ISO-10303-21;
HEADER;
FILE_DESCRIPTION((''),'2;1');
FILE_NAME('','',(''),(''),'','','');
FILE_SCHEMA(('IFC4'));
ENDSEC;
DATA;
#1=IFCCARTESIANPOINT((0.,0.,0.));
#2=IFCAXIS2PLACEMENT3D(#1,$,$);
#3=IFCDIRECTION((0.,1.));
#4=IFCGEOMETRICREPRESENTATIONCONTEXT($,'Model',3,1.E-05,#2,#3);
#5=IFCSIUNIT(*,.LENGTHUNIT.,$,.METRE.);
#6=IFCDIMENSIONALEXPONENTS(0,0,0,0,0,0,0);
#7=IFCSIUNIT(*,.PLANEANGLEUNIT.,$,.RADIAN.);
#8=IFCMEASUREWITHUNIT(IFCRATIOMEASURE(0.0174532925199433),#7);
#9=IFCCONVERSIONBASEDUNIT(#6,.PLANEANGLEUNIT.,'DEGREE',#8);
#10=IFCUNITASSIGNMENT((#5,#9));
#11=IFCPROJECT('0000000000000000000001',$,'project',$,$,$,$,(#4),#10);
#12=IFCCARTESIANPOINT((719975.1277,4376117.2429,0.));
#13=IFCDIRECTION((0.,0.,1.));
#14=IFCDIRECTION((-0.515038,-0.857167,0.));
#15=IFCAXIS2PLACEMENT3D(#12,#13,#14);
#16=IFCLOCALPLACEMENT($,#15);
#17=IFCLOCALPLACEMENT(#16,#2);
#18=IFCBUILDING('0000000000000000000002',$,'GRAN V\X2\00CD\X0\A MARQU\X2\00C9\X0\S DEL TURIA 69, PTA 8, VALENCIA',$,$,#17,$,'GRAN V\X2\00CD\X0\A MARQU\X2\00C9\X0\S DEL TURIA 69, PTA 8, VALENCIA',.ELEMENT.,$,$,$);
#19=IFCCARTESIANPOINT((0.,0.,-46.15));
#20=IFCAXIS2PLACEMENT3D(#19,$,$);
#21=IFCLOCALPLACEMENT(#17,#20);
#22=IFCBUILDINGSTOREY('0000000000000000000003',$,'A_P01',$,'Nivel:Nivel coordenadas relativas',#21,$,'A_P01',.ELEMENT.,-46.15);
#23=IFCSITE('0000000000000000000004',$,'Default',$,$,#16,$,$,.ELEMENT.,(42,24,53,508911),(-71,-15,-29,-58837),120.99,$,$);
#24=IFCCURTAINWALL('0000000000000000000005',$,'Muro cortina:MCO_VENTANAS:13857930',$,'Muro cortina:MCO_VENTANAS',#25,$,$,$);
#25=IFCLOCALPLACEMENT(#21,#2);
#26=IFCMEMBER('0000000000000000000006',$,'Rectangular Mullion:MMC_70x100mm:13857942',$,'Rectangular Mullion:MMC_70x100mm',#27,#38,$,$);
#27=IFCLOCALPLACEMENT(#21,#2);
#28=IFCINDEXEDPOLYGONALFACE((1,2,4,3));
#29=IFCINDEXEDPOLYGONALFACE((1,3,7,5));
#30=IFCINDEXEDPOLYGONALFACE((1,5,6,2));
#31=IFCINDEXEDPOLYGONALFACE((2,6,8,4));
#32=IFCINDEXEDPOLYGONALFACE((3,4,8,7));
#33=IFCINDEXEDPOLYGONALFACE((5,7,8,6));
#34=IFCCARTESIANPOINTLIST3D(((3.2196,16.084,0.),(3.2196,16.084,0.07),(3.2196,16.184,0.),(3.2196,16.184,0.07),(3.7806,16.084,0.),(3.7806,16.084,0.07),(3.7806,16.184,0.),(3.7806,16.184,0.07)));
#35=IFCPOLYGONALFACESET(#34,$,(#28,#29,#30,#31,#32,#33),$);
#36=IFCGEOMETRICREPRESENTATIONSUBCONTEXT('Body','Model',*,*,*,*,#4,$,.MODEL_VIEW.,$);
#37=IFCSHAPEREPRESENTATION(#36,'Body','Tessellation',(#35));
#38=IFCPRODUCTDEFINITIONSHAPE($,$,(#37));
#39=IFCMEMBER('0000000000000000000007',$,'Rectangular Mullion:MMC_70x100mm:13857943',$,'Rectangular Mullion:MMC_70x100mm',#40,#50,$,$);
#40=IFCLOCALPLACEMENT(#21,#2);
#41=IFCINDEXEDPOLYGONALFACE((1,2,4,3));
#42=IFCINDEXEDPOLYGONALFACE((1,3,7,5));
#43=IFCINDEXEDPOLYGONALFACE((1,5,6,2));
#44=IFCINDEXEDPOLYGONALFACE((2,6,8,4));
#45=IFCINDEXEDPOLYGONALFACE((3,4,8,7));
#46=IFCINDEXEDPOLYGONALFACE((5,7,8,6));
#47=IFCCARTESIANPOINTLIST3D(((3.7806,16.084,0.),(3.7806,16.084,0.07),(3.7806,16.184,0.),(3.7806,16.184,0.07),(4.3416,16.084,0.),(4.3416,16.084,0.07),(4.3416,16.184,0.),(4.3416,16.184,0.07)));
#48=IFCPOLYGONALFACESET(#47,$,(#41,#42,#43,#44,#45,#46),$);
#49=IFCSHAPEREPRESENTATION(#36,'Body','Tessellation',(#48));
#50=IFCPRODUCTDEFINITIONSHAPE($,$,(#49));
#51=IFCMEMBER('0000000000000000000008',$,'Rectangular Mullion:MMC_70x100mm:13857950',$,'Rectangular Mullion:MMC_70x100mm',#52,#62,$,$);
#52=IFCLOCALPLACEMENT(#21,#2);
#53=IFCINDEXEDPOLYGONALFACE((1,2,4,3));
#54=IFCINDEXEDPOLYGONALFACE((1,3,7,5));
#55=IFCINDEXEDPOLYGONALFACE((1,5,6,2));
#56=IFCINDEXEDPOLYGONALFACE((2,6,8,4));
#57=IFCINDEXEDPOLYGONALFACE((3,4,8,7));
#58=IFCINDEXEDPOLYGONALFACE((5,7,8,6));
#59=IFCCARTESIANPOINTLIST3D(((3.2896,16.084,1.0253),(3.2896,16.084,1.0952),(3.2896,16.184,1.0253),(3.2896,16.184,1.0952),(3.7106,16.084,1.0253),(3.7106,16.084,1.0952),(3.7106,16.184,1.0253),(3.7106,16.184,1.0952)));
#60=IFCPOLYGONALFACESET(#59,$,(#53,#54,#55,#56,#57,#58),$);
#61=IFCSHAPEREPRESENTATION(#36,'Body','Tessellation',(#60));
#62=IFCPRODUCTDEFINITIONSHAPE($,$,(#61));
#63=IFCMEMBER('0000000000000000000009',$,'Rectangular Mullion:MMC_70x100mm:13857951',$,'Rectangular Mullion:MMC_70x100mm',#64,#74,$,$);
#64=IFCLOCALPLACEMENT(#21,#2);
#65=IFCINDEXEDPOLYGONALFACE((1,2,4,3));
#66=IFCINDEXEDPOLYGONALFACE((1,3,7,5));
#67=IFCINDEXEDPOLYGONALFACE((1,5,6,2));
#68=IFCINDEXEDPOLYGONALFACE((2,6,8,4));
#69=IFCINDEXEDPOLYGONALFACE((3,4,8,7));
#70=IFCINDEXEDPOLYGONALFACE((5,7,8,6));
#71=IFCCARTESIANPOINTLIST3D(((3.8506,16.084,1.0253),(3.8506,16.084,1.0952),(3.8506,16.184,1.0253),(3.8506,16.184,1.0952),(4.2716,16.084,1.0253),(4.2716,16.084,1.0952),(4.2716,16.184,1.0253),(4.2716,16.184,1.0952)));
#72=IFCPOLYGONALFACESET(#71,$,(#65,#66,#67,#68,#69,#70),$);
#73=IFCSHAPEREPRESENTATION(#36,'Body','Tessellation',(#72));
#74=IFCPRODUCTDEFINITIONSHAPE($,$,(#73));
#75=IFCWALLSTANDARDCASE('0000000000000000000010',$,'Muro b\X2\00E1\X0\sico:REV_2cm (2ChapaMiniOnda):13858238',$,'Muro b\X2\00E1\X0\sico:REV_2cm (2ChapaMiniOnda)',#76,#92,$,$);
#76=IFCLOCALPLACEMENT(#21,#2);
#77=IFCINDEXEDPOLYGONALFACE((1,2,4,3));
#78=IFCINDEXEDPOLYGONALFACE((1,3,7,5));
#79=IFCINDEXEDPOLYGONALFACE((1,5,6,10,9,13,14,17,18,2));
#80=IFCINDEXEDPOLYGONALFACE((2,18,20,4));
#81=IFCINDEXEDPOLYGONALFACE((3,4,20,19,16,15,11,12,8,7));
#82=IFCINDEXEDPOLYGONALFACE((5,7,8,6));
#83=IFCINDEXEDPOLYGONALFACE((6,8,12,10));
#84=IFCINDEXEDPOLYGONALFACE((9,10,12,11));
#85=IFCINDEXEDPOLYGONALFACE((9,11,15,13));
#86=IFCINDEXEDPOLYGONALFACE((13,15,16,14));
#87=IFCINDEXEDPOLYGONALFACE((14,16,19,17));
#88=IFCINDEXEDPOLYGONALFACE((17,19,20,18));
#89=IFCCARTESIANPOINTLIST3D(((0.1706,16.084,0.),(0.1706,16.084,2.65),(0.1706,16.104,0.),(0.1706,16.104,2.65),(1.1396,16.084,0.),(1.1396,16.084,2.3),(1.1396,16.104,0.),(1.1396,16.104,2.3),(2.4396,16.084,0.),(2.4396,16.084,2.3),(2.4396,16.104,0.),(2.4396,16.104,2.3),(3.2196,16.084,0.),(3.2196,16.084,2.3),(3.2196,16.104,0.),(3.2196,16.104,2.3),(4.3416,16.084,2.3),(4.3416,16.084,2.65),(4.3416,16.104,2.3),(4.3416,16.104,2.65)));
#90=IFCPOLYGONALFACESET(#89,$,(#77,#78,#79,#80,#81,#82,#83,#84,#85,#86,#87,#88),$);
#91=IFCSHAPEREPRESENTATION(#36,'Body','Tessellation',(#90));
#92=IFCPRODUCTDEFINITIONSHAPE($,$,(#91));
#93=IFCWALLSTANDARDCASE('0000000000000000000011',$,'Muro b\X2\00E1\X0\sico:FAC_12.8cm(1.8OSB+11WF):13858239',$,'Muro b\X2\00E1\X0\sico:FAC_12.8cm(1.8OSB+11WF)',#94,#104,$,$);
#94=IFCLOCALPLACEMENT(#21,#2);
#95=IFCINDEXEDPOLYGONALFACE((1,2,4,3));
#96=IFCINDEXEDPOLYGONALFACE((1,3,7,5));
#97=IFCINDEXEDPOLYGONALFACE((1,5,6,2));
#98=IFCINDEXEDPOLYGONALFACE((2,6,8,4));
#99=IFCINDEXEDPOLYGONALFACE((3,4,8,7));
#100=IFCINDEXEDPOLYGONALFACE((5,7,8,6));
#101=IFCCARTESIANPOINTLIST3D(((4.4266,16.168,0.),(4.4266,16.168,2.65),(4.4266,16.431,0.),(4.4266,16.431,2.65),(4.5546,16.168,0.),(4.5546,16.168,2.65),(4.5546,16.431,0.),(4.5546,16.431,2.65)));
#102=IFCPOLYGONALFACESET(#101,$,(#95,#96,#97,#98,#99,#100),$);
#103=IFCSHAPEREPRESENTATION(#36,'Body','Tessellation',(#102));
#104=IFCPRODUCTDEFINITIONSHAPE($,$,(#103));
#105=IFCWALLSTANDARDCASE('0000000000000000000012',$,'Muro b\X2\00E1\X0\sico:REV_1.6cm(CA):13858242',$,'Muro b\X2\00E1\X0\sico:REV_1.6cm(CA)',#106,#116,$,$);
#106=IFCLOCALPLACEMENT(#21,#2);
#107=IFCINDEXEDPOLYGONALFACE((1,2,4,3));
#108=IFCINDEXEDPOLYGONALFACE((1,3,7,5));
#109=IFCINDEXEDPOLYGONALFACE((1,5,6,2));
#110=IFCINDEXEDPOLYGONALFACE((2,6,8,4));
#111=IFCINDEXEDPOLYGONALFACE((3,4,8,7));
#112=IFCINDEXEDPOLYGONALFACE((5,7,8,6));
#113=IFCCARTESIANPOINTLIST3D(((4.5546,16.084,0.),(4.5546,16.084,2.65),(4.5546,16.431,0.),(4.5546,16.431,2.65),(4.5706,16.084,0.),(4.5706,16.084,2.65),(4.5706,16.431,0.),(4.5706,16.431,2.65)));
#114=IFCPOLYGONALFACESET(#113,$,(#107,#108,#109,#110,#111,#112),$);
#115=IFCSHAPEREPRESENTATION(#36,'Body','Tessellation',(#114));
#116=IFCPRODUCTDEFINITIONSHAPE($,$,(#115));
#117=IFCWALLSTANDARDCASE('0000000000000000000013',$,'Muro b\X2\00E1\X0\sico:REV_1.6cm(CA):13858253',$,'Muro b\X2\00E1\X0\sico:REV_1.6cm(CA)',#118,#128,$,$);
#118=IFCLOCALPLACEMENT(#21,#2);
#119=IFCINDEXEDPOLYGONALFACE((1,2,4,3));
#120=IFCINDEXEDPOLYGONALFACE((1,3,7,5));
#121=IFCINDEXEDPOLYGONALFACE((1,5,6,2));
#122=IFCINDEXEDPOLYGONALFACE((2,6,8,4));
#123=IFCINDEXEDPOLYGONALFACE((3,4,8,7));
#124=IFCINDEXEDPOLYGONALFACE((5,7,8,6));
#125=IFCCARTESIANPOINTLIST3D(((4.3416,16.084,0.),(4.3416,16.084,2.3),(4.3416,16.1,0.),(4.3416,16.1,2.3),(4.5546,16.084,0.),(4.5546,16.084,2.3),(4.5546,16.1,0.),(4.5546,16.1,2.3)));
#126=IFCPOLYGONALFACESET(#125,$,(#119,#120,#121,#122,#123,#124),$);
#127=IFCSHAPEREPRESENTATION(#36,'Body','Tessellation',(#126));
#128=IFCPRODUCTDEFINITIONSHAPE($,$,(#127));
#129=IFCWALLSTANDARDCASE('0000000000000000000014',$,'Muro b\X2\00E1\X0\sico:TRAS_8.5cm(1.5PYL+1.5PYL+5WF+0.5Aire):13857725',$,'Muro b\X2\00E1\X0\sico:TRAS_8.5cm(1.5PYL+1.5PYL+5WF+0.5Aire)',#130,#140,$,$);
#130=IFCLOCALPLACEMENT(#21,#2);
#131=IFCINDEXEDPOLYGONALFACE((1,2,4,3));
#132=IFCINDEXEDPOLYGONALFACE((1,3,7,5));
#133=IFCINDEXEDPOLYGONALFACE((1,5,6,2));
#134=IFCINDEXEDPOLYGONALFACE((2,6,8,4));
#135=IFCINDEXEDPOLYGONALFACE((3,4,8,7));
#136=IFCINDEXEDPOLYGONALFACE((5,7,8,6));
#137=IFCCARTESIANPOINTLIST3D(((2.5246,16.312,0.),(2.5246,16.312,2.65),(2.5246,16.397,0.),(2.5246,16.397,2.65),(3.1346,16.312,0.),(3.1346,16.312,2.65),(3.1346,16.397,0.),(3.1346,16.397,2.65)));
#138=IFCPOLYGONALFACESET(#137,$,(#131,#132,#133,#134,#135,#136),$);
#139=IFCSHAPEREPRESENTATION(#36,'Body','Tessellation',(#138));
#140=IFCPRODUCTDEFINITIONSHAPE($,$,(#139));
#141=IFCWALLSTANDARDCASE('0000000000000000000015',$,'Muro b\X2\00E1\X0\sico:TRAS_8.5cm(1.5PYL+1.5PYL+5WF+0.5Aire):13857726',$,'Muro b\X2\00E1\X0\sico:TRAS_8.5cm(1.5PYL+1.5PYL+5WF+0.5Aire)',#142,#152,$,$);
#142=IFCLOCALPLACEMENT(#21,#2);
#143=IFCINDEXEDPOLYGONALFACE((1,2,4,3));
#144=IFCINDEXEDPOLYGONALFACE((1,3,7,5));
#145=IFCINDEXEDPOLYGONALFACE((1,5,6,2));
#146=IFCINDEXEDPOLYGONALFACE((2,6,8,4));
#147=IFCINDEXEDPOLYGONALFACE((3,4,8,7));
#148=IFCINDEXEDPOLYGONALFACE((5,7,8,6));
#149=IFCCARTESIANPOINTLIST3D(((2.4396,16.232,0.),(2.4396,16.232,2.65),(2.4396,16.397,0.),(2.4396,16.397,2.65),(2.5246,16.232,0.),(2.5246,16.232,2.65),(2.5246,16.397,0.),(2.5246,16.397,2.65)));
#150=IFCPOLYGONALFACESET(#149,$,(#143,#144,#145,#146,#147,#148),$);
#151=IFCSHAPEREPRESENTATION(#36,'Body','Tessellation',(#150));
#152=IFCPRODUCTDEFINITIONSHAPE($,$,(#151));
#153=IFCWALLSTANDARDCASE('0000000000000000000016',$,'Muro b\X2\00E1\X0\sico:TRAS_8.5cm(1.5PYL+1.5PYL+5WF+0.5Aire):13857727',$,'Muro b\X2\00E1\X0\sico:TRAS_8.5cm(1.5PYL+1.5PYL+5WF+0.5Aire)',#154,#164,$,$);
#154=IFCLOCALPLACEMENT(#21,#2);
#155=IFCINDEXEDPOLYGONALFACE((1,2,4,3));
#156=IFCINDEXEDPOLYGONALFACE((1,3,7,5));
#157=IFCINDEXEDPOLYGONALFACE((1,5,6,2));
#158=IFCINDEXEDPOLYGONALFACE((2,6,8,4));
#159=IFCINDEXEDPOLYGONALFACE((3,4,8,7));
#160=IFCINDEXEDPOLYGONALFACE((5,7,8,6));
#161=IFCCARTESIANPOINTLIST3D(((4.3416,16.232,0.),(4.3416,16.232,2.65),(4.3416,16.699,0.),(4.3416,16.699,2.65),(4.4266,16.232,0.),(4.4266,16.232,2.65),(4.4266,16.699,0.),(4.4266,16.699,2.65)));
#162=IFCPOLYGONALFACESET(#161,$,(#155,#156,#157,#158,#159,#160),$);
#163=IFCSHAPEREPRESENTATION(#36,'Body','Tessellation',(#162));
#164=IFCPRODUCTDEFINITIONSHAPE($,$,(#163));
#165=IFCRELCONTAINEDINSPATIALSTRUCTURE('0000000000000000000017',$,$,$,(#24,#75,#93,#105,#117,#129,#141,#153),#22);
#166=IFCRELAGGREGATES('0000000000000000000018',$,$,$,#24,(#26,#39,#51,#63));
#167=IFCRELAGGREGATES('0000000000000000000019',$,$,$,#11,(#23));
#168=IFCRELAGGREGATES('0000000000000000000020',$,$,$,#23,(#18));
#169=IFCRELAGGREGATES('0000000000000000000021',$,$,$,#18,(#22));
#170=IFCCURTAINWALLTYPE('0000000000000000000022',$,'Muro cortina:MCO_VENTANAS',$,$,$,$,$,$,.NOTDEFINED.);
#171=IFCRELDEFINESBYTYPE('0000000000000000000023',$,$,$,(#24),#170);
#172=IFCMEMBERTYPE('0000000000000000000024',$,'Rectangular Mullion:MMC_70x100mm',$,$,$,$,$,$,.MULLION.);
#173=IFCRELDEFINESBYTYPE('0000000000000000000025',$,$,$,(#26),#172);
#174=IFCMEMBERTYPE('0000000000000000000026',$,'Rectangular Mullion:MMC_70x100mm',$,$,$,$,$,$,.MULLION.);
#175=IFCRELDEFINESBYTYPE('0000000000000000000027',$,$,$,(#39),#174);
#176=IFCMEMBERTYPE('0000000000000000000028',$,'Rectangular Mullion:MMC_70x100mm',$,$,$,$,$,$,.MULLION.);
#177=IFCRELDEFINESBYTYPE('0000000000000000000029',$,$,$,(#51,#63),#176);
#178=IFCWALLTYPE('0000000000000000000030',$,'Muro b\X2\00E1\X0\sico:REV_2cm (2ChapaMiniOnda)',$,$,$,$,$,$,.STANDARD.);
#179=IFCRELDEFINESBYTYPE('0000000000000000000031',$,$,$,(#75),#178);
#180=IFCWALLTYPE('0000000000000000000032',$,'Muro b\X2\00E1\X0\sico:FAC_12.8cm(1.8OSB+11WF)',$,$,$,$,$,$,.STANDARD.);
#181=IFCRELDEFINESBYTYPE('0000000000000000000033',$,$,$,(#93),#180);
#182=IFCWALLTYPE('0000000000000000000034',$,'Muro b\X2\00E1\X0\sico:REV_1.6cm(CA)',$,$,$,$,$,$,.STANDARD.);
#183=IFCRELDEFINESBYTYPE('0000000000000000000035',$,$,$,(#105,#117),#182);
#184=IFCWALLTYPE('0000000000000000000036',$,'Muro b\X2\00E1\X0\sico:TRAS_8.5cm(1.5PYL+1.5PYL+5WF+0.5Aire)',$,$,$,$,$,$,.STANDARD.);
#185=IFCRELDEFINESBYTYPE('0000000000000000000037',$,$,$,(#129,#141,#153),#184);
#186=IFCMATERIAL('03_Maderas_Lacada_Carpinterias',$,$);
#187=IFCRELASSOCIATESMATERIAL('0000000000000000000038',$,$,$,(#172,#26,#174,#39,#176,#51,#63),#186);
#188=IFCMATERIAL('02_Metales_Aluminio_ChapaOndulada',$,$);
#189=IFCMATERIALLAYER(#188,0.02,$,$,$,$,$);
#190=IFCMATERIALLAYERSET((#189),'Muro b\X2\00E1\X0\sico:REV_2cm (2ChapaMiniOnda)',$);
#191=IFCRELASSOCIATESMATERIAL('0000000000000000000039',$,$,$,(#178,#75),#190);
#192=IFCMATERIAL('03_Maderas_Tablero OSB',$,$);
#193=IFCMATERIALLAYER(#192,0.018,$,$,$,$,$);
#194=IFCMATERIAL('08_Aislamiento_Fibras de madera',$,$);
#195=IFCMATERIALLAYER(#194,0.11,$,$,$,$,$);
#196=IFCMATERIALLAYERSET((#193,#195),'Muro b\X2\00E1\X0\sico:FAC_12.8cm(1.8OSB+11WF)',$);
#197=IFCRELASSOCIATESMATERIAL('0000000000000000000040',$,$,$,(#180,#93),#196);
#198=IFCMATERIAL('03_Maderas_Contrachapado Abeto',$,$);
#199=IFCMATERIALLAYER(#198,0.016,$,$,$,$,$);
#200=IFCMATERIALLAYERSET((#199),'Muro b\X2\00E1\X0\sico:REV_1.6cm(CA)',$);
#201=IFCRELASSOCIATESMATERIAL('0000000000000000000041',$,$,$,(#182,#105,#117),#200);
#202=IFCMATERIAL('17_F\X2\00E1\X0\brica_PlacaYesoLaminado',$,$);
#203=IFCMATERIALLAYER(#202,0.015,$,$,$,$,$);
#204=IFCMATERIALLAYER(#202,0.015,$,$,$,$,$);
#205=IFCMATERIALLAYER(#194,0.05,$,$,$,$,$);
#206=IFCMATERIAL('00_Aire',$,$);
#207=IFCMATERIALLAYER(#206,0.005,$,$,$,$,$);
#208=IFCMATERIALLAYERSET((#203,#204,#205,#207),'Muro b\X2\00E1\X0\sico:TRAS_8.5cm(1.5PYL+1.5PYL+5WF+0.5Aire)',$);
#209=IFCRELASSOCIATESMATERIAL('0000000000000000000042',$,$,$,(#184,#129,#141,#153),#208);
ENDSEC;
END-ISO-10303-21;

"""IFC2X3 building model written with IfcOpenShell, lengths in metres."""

from ifc_helpers import new_model, entity, si_unit, converted_unit, direction, frame, frame_2d, origin, origin_2d_with_axis, place, context, subcontext, project, spatial, rectangle, extrude, source, transform, mapped, material, layer, layer_set, layer_usage, type_object, type_shapes, element, aggregate, save


model = new_model("IFC2X3")

# Units and contexts
model_context = context("Model", 3, precision=1e-05, world=origin(), true_north=direction((0.0, 1.0)))
body_context = subcontext(model_context, "Body", "Model", "MODEL_VIEW")
ifc_project = project(units=[si_unit("LENGTHUNIT", "METRE"), converted_unit("PLANEANGLEUNIT", "DEGREE", entity("IfcRatioMeasure", 0.0174532925199433), si_unit("PLANEANGLEUNIT", "RADIAN"), dimensions=[0, 0, 0, 0, 0, 0, 0])], contexts=[model_context])

# Site, building, storey
site_placement = place(None, frame((719975.1277, 4376117.2429, 0.0), z_axis=(0.0, 0.0, 1.0), x_axis=(-0.515038, -0.857167, 0.0)))
site = spatial("IfcSite", under=ifc_project, at=site_placement, Name="Default", CompositionType="ELEMENT", RefLatitude=(42, 24, 53, 508911), RefLongitude=(-71, -15, -29, -58837), RefElevation=120.99)
building_placement = place(site_placement, origin())
building = spatial("IfcBuilding", under=site, at=building_placement, Name="GRAN VÍA MARQUÉS DEL TURIA 69, PTA 8, VALENCIA", LongName="GRAN VÍA MARQUÉS DEL TURIA 69, PTA 8, VALENCIA", CompositionType="ELEMENT")
storey_placement = place(building_placement, frame((0.0, 0.0, -46.15)))
storey = spatial("IfcBuildingStorey", under=building, at=storey_placement, Name="A_P01", ObjectType="Nivel:Nivel coordenadas relativas", LongName="A_P01", CompositionType="ELEMENT", Elevation=-46.15)

# Shared definitions
curtain_wall_type = type_object("IfcCurtainWallType", Name="Muro cortina:MCO_VENTANAS", PredefinedType="NOTDEFINED")
ifc_material_1 = material(Name="03_Maderas_Lacada_Carpinterias")

# Curtain wall
curtain_wall_1_placement = place(storey_placement, frame((0.0, 0.0, 46.15)))
curtain_wall_1 = element("IfcCurtainWall", 1, at=curtain_wall_1_placement, inside=storey, type_object=curtain_wall_type, Name="Muro cortina:MCO_VENTANAS:13857930", ObjectType="Muro cortina:MCO_VENTANAS")

# Members
member_type_1 = type_object("IfcMemberType", Name="Rectangular Mullion:MMC_70x100mm", PredefinedType="MULLION", material=ifc_material_1)
shared_shape_1 = source(origin(), body_context, "Body", "SweptSolid", [
    extrude(rectangle(XDim=0.1, YDim=0.07, at=origin_2d_with_axis()), frame((-0.035, 0.0, -0.561), z_axis=(0.0, 0.0, 1.0), x_axis=(0.0, -1.0, 0.0)), (0.0, 0.0, 1.0), 0.561),
])
type_shapes(member_type_1, [shared_shape_1])
member_1_placement = place(storey_placement, frame((3.2196, 16.134, 0.0), z_axis=(-1.0, 0.0, 0.0), x_axis=(0.0, 0.0, -1.0)))
member_1 = element("IfcMember", 2, at=member_1_placement, type_object=member_type_1, material=ifc_material_1, Name="Rectangular Mullion:MMC_70x100mm:13857942", ObjectType="Rectangular Mullion:MMC_70x100mm", context=body_context, shape_type="MappedRepresentation", body=[
    mapped(shared_shape_1, transform((0.0, 0.0, 0.0), scale=1.0)),
])
member_type_2 = type_object("IfcMemberType", Name="Rectangular Mullion:MMC_70x100mm", PredefinedType="MULLION", material=ifc_material_1)
shared_shape_2 = source(origin(), body_context, "Body", "SweptSolid", [
    extrude(rectangle(XDim=0.1, YDim=0.07, at=origin_2d_with_axis()), frame((-0.035, 0.0, -0.561), z_axis=(0.0, 0.0, 1.0), x_axis=(0.0, -1.0, 0.0)), (0.0, 0.0, 1.0), 0.561),
])
type_shapes(member_type_2, [shared_shape_2])
member_2_placement = place(storey_placement, frame((3.7806, 16.134, 0.0), z_axis=(-1.0, 0.0, 0.0), x_axis=(0.0, 0.0, -1.0)))
member_2 = element("IfcMember", 3, at=member_2_placement, type_object=member_type_2, material=ifc_material_1, Name="Rectangular Mullion:MMC_70x100mm:13857943", ObjectType="Rectangular Mullion:MMC_70x100mm", context=body_context, shape_type="MappedRepresentation", body=[
    mapped(shared_shape_2, transform((0.0, 0.0, 0.0), scale=1.0)),
])
member_type_3 = type_object("IfcMemberType", Name="Rectangular Mullion:MMC_70x100mm", PredefinedType="MULLION", material=ifc_material_1)
shared_shape_3 = source(origin(), body_context, "Body", "SweptSolid", [
    extrude(rectangle(XDim=0.1, YDim=0.07, at=origin_2d_with_axis()), frame((0.0, 0.0, -0.421), z_axis=(0.0, 0.0, 1.0), x_axis=(0.0, -1.0, 0.0)), (0.0, 0.0, 1.0), 0.421),
])
type_shapes(member_type_3, [shared_shape_3])
member_3_placement = place(storey_placement, frame((3.7106, 16.134, 1.0602), z_axis=(1.0, 0.0, 0.0), x_axis=(0.0, 0.0, 1.0)))
member_3 = element("IfcMember", 4, at=member_3_placement, type_object=member_type_3, material=ifc_material_1, Name="Rectangular Mullion:MMC_70x100mm:13857950", ObjectType="Rectangular Mullion:MMC_70x100mm", context=body_context, shape_type="MappedRepresentation", body=[
    mapped(shared_shape_3, transform((0.0, 0.0, 0.0), scale=1.0)),
])
member_4_placement = place(storey_placement, frame((4.2716, 16.134, 1.0602), z_axis=(1.0, 0.0, 0.0), x_axis=(0.0, 0.0, 1.0)))
member_4 = element("IfcMember", 5, at=member_4_placement, type_object=member_type_3, material=ifc_material_1, Name="Rectangular Mullion:MMC_70x100mm:13857951", ObjectType="Rectangular Mullion:MMC_70x100mm", context=body_context, shape_type="MappedRepresentation", body=[
    mapped(shared_shape_3, transform((0.0, 0.0, 0.0), scale=1.0)),
])

aggregate(curtain_wall_1, [member_1, member_2, member_3, member_4])

# Wall, openings
ifc_material_2 = material(Name="02_Metales_Aluminio_ChapaOndulada")
ifc_layer_1 = layer(ifc_material_2, 0.02)
ifc_layer_set_1 = layer_set([ifc_layer_1], Name="Muro básico:REV_2cm (2ChapaMiniOnda)")
ifc_layer_usage_1 = layer_usage(ifc_layer_set_1, "AXIS2", "NEGATIVE", 0.01)
wall_type_1 = type_object("IfcWallType", Name="Muro básico:REV_2cm (2ChapaMiniOnda)", PredefinedType="STANDARD", material=ifc_layer_set_1)
wall_1_placement = place(storey_placement, frame((4.3416, 16.094, 0.0), z_axis=(0.0, 0.0, 1.0), x_axis=(-1.0, 0.0, 0.0)))
wall_1 = element("IfcWallStandardCase", 6, at=wall_1_placement, inside=storey, type_object=wall_type_1, material=ifc_layer_usage_1, Name="Muro básico:REV_2cm (2ChapaMiniOnda):13858238", ObjectType="Muro básico:REV_2cm (2ChapaMiniOnda)", context=body_context, shape_type="SweptSolid", body=[
    extrude(rectangle(XDim=4.171, YDim=0.02, at=frame_2d((2.0855, 0.0), x_axis=(-1.0, 0.0))), origin(), (0.0, 0.0, 1.0), 2.65),
])
opening_1_placement = place(wall_1_placement, origin())
element("IfcOpeningElement", 7, at=opening_1_placement, cuts=wall_1, ObjectType="Opening", context=body_context, shape_type="SweptSolid", body=[
    extrude(rectangle(XDim=2.3, YDim=1.122, at=frame_2d((0.0, 0.0), x_axis=(1.0, 0.0))), frame((0.561, -0.01, 1.15), z_axis=(0.0, 1.0, 0.0), x_axis=(0.0, 0.0, -1.0)), (0.0, 0.0, 1.0), 0.02),
])
opening_2_placement = place(wall_1_placement, origin())
element("IfcOpeningElement", 8, at=opening_2_placement, cuts=wall_1, ObjectType="Opening", context=body_context, shape_type="SweptSolid", body=[
    extrude(rectangle(XDim=2.3, YDim=1.3, at=frame_2d((0.0, 0.0), x_axis=(0.0, 1.0))), frame((2.552, -0.1624, 1.15), z_axis=(0.0, 1.0, 0.0), x_axis=(-1.0, 0.0, 0.0)), (0.0, 0.0, 1.0), 0.3248),
])
ifc_material_3 = material(Name="03_Maderas_Tablero OSB")
ifc_layer_2 = layer(ifc_material_3, 0.018)
ifc_material_4 = material(Name="08_Aislamiento_Fibras de madera")
ifc_layer_3 = layer(ifc_material_4, 0.11)
ifc_layer_set_2 = layer_set([ifc_layer_2, ifc_layer_3], Name="Muro básico:FAC_12.8cm(1.8OSB+11WF)")
wall_type_2 = type_object("IfcWallType", Name="Muro básico:FAC_12.8cm(1.8OSB+11WF)", PredefinedType="STANDARD", material=ifc_layer_set_2)

# Walls
ifc_layer_usage_2 = layer_usage(ifc_layer_set_2, "AXIS2", "NEGATIVE", 0.064)
wall_2_placement = place(storey_placement, frame((4.4906, 16.431, 0.0), z_axis=(0.0, 0.0, 1.0), x_axis=(0.0, -1.0, 0.0)))
element("IfcWallStandardCase", 9, at=wall_2_placement, inside=storey, type_object=wall_type_2, material=ifc_layer_usage_2, Name="Muro básico:FAC_12.8cm(1.8OSB+11WF):13858239", ObjectType="Muro básico:FAC_12.8cm(1.8OSB+11WF)", context=body_context, shape_type="SweptSolid", body=[
    extrude(rectangle(XDim=0.263, YDim=0.128, at=frame_2d((0.1315, 0.0), x_axis=(-1.0, 0.0))), origin(), (0.0, 0.0, 1.0), 2.65),
])
ifc_material_5 = material(Name="03_Maderas_Contrachapado Abeto")
ifc_layer_4 = layer(ifc_material_5, 0.016)
ifc_layer_set_3 = layer_set([ifc_layer_4], Name="Muro básico:REV_1.6cm(CA)")
ifc_layer_usage_3 = layer_usage(ifc_layer_set_3, "AXIS2", "NEGATIVE", 0.008)
wall_type_3 = type_object("IfcWallType", Name="Muro básico:REV_1.6cm(CA)", PredefinedType="STANDARD", material=ifc_layer_set_3)
wall_3_placement = place(storey_placement, frame((4.5626, 16.084, 0.0), z_axis=(0.0, 0.0, 1.0), x_axis=(0.0, 1.0, 0.0)))
element("IfcWallStandardCase", 10, at=wall_3_placement, inside=storey, type_object=wall_type_3, material=ifc_layer_usage_3, Name="Muro básico:REV_1.6cm(CA):13858242", ObjectType="Muro básico:REV_1.6cm(CA)", context=body_context, shape_type="SweptSolid", body=[
    extrude(rectangle(XDim=0.347, YDim=0.016, at=frame_2d((0.1735, 0.0), x_axis=(-1.0, 0.0))), origin(), (0.0, 0.0, 1.0), 2.65),
])
ifc_layer_usage_4 = layer_usage(ifc_layer_set_3, "AXIS2", "NEGATIVE", 0.008)
wall_4_placement = place(storey_placement, frame((4.3416, 16.092, 0.0)))
element("IfcWallStandardCase", 11, at=wall_4_placement, inside=storey, type_object=wall_type_3, material=ifc_layer_usage_4, Name="Muro básico:REV_1.6cm(CA):13858253", ObjectType="Muro básico:REV_1.6cm(CA)", context=body_context, shape_type="SweptSolid", body=[
    extrude(rectangle(XDim=0.213, YDim=0.016, at=frame_2d((0.1065, 0.0), x_axis=(-1.0, 0.0))), origin(), (0.0, 0.0, 1.0), 2.3),
])
ifc_material_6 = material(Name="17_Fábrica_PlacaYesoLaminado")
ifc_layer_5 = layer(ifc_material_6, 0.015)
ifc_layer_6 = layer(ifc_material_6, 0.015)
ifc_layer_7 = layer(ifc_material_4, 0.05)
ifc_material_7 = material(Name="00_Aire")
ifc_layer_8 = layer(ifc_material_7, 0.005)
ifc_layer_set_4 = layer_set([ifc_layer_5, ifc_layer_6, ifc_layer_7, ifc_layer_8], Name="Muro básico:TRAS_8.5cm(1.5PYL+1.5PYL+5WF+0.5Aire)")
ifc_layer_usage_5 = layer_usage(ifc_layer_set_4, "AXIS2", "NEGATIVE", 0.0425)
wall_type_4 = type_object("IfcWallType", Name="Muro básico:TRAS_8.5cm(1.5PYL+1.5PYL+5WF+0.5Aire)", PredefinedType="STANDARD", material=ifc_layer_set_4)
wall_5_placement = place(storey_placement, frame((2.5246, 16.3545, 0.0)))
element("IfcWallStandardCase", 12, at=wall_5_placement, inside=storey, type_object=wall_type_4, material=ifc_layer_usage_5, Name="Muro básico:TRAS_8.5cm(1.5PYL+1.5PYL+5WF+0.5Aire):13857725", ObjectType="Muro básico:TRAS_8.5cm(1.5PYL+1.5PYL+5WF+0.5Aire)", context=body_context, shape_type="SweptSolid", body=[
    extrude(rectangle(XDim=0.61, YDim=0.085, at=frame_2d((0.305, 0.0), x_axis=(-1.0, 0.0))), origin(), (0.0, 0.0, 1.0), 2.65),
])
ifc_layer_usage_6 = layer_usage(ifc_layer_set_4, "AXIS2", "NEGATIVE", 0.0425)
wall_6_placement = place(storey_placement, frame((2.4821, 16.232, 0.0), z_axis=(0.0, 0.0, 1.0), x_axis=(0.0, 1.0, 0.0)))
element("IfcWallStandardCase", 13, at=wall_6_placement, inside=storey, type_object=wall_type_4, material=ifc_layer_usage_6, Name="Muro básico:TRAS_8.5cm(1.5PYL+1.5PYL+5WF+0.5Aire):13857726", ObjectType="Muro básico:TRAS_8.5cm(1.5PYL+1.5PYL+5WF+0.5Aire)", context=body_context, shape_type="SweptSolid", body=[
    extrude(rectangle(XDim=0.165, YDim=0.085, at=frame_2d((0.0825, 0.0), x_axis=(-1.0, 0.0))), origin(), (0.0, 0.0, 1.0), 2.65),
])
ifc_layer_usage_7 = layer_usage(ifc_layer_set_4, "AXIS2", "NEGATIVE", 0.0425)
wall_7_placement = place(storey_placement, frame((4.3841, 16.232, 0.0), z_axis=(0.0, 0.0, 1.0), x_axis=(0.0, 1.0, 0.0)))
element("IfcWallStandardCase", 14, at=wall_7_placement, inside=storey, type_object=wall_type_4, material=ifc_layer_usage_7, Name="Muro básico:TRAS_8.5cm(1.5PYL+1.5PYL+5WF+0.5Aire):13857727", ObjectType="Muro básico:TRAS_8.5cm(1.5PYL+1.5PYL+5WF+0.5Aire)", context=body_context, shape_type="SweptSolid", body=[
    extrude(rectangle(XDim=0.467, YDim=0.085, at=frame_2d((0.2335, 0.0), x_axis=(-1.0, 0.0))), origin(), (0.0, 0.0, 1.0), 2.65),
])

save(model, "model.ifc")
